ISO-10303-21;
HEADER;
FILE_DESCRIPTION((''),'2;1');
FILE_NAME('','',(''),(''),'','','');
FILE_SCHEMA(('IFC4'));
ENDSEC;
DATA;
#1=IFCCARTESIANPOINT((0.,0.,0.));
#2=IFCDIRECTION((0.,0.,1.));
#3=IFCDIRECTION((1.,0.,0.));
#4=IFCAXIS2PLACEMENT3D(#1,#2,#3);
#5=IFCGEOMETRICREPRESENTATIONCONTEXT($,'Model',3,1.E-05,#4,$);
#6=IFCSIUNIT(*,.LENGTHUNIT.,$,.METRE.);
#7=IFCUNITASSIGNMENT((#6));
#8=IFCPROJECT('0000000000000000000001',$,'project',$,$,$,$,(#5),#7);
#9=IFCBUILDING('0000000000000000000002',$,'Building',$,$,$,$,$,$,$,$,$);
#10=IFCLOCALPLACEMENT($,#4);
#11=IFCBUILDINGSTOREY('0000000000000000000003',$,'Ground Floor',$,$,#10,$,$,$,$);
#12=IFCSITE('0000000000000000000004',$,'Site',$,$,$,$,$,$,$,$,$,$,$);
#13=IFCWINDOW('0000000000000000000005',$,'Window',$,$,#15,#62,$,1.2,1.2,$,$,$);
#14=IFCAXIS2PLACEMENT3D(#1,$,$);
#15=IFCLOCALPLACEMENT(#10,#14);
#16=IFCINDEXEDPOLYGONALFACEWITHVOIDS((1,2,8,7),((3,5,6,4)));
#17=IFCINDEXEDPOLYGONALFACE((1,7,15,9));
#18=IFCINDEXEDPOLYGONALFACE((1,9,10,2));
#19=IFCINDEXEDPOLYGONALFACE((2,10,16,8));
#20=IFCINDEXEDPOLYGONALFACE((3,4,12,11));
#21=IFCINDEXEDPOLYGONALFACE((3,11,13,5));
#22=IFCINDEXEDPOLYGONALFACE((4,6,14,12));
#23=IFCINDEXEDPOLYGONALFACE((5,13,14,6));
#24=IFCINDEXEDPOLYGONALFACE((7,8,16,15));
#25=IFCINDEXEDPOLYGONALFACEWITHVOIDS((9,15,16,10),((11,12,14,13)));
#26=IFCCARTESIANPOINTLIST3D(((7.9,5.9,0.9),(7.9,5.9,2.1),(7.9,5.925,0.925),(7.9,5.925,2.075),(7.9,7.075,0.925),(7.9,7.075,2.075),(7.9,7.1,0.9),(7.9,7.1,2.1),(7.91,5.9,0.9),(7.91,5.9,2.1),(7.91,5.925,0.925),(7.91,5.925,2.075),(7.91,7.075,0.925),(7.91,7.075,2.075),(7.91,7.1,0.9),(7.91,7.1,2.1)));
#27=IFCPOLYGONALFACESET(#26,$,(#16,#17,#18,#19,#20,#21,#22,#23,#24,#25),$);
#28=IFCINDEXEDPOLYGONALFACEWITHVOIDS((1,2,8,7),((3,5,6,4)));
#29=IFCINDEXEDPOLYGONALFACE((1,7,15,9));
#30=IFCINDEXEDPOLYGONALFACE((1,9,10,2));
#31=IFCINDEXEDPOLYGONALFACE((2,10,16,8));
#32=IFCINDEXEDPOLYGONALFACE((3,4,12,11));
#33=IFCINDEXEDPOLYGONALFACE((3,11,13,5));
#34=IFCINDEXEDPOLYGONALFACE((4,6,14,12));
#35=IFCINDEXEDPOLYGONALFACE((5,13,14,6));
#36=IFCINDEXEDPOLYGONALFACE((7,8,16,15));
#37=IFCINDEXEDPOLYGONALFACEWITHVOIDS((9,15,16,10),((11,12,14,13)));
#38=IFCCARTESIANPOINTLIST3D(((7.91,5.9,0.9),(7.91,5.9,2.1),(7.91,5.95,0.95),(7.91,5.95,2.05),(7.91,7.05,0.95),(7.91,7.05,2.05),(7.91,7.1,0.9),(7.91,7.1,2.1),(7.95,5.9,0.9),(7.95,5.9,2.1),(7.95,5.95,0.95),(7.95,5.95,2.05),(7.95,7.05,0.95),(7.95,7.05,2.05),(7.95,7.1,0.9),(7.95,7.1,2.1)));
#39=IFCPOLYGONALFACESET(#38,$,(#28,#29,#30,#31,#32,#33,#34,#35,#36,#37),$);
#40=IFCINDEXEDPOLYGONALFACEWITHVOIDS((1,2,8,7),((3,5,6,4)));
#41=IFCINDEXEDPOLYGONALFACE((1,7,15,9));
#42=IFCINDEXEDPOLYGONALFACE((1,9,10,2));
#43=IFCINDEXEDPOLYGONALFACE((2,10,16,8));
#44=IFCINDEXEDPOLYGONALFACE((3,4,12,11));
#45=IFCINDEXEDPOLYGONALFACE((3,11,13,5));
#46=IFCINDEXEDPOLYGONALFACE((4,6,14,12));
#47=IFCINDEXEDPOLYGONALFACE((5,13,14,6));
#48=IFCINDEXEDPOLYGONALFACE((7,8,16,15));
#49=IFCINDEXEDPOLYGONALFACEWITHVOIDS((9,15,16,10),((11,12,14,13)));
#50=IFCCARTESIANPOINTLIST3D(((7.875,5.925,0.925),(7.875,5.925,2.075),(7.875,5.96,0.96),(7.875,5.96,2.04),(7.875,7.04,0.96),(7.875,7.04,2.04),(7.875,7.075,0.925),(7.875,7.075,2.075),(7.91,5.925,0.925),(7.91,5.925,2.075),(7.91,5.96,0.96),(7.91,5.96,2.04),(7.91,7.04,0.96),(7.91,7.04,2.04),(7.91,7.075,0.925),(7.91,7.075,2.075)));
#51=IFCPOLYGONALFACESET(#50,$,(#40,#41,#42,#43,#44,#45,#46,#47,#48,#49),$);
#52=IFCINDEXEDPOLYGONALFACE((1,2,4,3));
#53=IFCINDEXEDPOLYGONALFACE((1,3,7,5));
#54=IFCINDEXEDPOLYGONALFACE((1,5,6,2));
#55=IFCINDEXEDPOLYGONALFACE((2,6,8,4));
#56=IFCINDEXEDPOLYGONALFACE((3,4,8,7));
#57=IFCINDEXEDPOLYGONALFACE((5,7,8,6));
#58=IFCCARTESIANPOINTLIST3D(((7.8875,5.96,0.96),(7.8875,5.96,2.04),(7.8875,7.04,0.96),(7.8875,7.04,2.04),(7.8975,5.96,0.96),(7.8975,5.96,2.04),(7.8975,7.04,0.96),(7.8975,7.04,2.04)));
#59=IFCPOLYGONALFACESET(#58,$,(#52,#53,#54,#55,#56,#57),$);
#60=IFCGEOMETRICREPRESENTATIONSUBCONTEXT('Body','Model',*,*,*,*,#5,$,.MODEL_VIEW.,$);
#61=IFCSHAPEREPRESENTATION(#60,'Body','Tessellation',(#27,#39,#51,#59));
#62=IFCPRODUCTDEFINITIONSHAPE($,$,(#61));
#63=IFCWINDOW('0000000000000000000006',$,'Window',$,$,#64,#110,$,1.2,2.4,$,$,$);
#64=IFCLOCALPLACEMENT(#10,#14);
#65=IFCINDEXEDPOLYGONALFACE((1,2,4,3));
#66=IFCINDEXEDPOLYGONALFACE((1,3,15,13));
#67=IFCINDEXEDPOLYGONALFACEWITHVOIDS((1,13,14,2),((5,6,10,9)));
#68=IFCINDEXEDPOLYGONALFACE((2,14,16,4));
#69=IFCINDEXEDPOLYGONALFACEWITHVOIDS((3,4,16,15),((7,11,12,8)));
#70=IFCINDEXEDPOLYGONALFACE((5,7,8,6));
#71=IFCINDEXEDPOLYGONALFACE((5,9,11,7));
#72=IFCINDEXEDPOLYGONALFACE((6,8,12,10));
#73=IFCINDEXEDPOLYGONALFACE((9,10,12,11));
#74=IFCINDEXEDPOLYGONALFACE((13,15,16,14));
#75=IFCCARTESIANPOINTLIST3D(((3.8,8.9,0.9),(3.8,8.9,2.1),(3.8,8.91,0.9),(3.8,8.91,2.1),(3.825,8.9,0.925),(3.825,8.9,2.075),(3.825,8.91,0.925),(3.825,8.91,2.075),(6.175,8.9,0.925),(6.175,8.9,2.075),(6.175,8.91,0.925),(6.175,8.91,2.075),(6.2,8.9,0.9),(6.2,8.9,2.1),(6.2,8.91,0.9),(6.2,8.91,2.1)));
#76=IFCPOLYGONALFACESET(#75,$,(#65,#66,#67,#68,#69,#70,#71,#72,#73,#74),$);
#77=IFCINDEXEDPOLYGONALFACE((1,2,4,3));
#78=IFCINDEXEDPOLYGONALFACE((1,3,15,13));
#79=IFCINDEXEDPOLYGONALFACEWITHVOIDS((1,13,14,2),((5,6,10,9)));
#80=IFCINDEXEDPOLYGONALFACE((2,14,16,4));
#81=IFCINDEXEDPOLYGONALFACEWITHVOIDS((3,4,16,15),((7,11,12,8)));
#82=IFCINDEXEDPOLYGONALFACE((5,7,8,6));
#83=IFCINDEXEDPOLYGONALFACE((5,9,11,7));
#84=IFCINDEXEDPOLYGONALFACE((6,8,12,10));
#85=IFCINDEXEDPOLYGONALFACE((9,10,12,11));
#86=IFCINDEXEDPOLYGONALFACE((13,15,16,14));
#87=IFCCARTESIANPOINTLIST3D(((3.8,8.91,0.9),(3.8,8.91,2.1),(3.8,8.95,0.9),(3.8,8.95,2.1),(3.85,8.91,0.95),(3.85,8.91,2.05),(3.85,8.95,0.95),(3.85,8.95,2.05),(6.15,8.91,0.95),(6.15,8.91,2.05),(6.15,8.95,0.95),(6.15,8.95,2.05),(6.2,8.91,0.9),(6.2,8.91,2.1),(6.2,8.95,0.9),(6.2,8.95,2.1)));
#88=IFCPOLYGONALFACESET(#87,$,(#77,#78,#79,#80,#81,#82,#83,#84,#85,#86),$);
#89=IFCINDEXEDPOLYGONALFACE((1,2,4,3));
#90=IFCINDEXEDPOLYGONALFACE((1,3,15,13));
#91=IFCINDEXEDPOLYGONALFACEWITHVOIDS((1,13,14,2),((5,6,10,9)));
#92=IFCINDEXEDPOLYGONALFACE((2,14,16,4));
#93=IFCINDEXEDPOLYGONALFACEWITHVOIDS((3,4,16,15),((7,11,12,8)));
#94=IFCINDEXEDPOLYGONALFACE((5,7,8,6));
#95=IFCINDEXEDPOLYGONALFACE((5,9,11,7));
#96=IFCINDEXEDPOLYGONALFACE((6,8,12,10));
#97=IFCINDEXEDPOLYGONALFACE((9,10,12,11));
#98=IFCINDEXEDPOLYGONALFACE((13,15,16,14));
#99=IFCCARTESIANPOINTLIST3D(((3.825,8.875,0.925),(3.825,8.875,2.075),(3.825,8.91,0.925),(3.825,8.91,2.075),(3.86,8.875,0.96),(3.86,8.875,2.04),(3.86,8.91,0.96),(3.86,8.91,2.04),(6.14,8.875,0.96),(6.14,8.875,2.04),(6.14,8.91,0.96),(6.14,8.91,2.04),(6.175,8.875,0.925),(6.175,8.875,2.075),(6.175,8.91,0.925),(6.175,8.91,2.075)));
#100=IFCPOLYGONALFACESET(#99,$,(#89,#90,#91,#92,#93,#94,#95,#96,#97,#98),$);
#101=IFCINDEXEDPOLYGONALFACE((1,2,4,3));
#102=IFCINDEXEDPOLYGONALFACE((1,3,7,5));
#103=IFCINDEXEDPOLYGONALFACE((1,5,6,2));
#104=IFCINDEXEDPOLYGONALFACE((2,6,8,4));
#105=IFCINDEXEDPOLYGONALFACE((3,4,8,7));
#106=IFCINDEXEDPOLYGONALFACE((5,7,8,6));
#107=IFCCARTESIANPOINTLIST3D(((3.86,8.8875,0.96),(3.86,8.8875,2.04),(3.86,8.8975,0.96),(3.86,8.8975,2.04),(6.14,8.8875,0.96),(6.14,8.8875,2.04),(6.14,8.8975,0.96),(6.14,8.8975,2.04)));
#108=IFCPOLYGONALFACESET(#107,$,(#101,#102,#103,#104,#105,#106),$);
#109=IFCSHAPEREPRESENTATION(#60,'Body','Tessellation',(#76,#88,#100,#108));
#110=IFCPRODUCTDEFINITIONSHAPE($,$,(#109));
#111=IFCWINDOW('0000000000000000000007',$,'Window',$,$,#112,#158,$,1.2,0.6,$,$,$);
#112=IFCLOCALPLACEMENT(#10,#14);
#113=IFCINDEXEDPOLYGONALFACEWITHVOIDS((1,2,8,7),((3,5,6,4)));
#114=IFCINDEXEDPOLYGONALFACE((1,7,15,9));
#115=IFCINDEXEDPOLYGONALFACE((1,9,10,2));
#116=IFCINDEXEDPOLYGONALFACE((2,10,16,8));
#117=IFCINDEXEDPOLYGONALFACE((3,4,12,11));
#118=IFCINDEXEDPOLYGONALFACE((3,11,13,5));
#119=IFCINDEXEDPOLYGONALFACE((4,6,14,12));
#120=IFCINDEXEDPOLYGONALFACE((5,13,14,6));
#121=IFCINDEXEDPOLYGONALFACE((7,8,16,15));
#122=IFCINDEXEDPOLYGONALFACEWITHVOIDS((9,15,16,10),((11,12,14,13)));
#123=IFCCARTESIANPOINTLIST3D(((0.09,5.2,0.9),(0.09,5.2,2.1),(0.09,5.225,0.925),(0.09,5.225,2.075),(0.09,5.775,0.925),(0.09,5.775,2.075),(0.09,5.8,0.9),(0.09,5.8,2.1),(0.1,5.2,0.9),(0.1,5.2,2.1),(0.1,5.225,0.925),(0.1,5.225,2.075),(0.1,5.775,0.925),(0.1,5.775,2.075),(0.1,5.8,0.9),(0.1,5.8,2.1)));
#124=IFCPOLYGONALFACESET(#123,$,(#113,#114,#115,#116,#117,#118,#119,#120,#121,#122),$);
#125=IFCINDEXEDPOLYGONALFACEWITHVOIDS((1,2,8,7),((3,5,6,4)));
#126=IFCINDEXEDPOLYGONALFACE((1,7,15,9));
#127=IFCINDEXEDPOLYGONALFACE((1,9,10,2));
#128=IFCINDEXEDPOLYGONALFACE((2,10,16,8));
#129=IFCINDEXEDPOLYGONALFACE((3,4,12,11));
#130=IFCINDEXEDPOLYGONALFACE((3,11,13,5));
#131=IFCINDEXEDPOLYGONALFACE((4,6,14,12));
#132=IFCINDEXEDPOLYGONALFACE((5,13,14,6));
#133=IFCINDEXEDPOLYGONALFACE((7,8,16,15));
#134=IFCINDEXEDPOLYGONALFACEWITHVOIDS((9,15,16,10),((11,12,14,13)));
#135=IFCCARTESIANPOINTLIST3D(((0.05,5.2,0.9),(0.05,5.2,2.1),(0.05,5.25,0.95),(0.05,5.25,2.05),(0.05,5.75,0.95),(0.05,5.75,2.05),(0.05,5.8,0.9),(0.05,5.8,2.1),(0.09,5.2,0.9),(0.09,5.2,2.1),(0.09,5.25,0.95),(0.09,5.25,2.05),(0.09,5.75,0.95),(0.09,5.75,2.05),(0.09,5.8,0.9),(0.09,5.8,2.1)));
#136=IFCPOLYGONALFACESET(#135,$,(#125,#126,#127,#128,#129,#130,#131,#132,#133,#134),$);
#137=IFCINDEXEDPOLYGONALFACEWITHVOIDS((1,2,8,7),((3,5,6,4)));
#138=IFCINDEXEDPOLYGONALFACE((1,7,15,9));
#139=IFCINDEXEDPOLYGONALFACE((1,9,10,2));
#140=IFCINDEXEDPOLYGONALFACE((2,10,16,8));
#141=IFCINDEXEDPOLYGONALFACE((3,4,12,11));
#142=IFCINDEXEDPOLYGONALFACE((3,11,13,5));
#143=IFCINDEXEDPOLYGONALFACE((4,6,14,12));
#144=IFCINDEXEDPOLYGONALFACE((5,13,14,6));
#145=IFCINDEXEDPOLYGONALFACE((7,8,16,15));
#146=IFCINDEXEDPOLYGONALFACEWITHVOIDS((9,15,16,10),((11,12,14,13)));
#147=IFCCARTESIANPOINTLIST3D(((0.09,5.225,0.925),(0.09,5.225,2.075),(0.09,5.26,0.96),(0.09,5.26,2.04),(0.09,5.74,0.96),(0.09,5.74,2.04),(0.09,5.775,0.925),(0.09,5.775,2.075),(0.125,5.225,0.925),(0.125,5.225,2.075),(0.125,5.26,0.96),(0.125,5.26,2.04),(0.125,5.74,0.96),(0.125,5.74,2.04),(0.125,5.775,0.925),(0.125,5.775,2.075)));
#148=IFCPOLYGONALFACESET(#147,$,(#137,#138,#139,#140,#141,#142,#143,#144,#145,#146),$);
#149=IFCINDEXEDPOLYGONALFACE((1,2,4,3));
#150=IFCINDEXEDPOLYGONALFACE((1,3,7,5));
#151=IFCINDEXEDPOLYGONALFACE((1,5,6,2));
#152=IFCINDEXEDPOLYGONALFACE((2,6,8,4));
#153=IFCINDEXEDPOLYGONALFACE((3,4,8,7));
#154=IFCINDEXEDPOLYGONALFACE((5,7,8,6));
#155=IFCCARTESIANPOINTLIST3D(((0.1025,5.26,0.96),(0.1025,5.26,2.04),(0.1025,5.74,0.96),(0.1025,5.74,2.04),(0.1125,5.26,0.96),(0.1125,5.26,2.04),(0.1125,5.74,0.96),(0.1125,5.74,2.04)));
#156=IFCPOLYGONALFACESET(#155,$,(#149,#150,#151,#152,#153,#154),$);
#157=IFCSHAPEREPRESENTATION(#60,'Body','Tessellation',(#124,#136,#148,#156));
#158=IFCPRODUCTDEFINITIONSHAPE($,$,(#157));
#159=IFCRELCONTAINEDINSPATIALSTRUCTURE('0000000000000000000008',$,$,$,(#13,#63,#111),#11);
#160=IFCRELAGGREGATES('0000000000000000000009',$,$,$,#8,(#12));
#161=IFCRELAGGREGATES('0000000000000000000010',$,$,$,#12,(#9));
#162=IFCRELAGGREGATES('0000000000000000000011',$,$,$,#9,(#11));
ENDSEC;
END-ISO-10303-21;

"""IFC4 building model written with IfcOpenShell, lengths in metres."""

from ifc_helpers import new_model, si_unit, frame, origin_with_axes, place, context, subcontext, project, spatial, line, indexed_curve, outline, extrude, element, save


model = new_model("IFC4")

# Units and contexts
model_context = context("Model", 3, precision=1e-05, world=origin_with_axes())
body_context = subcontext(model_context, "Body", "Model", "MODEL_VIEW")
ifc_project = project(units=[si_unit("LENGTHUNIT", "METRE")], contexts=[model_context])

# Site, building, storey
site = spatial("IfcSite", under=ifc_project, Name="Site")
building = spatial("IfcBuilding", under=site, Name="Building")
storey_placement = place(None, origin_with_axes())
storey = spatial("IfcBuildingStorey", under=building, at=storey_placement, Name="Ground Floor")

# Windows
window_1_placement = place(storey_placement, frame((8.0, 5.9, 0.9), z_axis=(0.0, 0.0, 1.0), x_axis=(0.0, 1.0, 0.0)))
element("IfcWindow", 1, at=window_1_placement, inside=storey, Name="Window", OverallHeight=1.2, OverallWidth=1.2, context=body_context, shape_type="SweptSolid", body=[
    extrude(outline(indexed_curve([(0.0, 0.0), (1.2, 0.0), (1.2, 1.2), (0.0, 1.2)], segments=[line(1, 2, 3, 4, 1)]), holes=[indexed_curve([(0.025, 0.025), (1.175, 0.025), (1.175, 1.175), (0.025, 1.175)], segments=[line(1, 2, 3, 4, 1)])]), frame((0.0, 0.09, 0.0), z_axis=(0.0, -1.0, 0.0), x_axis=(1.0, 0.0, 0.0)), (0.0, 0.0, -1.0), 0.01),
    extrude(outline(indexed_curve([(0.0, 0.0), (1.2, 0.0), (1.2, 1.2), (0.0, 1.2)], segments=[line(1, 2, 3, 4, 1)]), holes=[indexed_curve([(0.05, 0.05), (1.15, 0.05), (1.15, 1.15), (0.05, 1.15)], segments=[line(1, 2, 3, 4, 1)])]), frame((0.0, 0.05, 0.0), z_axis=(0.0, -1.0, 0.0), x_axis=(1.0, 0.0, 0.0)), (0.0, 0.0, -1.0), 0.04),
    extrude(outline(indexed_curve([(0.0, 0.0), (1.15, 0.0), (1.15, 1.15), (0.0, 1.15)], segments=[line(1, 2, 3, 4, 1)]), holes=[indexed_curve([(0.035, 0.035), (1.115, 0.035), (1.115, 1.115), (0.035, 1.115)], segments=[line(1, 2, 3, 4, 1)])]), frame((0.025, 0.09, 0.025), z_axis=(0.0, -1.0, 0.0), x_axis=(1.0, 0.0, 0.0)), (0.0, 0.0, -1.0), 0.035),
    extrude(outline(indexed_curve([(0.035, 0.035), (1.115, 0.035), (1.115, 1.115), (0.035, 1.115)], segments=[line(1, 2, 3, 4, 1)])), frame((0.025, 0.1025, 0.025), z_axis=(0.0, -1.0, 0.0), x_axis=(1.0, 0.0, 0.0)), (0.0, 0.0, -1.0), 0.01),
])
window_2_placement = place(storey_placement, frame((6.2, 9.0, 0.9), z_axis=(0.0, 0.0, 1.0), x_axis=(-1.0, 0.0, 0.0)))
element("IfcWindow", 2, at=window_2_placement, inside=storey, Name="Window", OverallHeight=1.2, OverallWidth=2.4, context=body_context, shape_type="SweptSolid", body=[
    extrude(outline(indexed_curve([(0.0, 0.0), (2.4, 0.0), (2.4, 1.2), (0.0, 1.2)], segments=[line(1, 2, 3, 4, 1)]), holes=[indexed_curve([(0.025, 0.025), (2.375, 0.025), (2.375, 1.175), (0.025, 1.175)], segments=[line(1, 2, 3, 4, 1)])]), frame((0.0, 0.09, 0.0), z_axis=(0.0, -1.0, 0.0), x_axis=(1.0, 0.0, 0.0)), (0.0, 0.0, -1.0), 0.01),
    extrude(outline(indexed_curve([(0.0, 0.0), (2.4, 0.0), (2.4, 1.2), (0.0, 1.2)], segments=[line(1, 2, 3, 4, 1)]), holes=[indexed_curve([(0.05, 0.05), (2.35, 0.05), (2.35, 1.15), (0.05, 1.15)], segments=[line(1, 2, 3, 4, 1)])]), frame((0.0, 0.05, 0.0), z_axis=(0.0, -1.0, 0.0), x_axis=(1.0, 0.0, 0.0)), (0.0, 0.0, -1.0), 0.04),
    extrude(outline(indexed_curve([(0.0, 0.0), (2.35, 0.0), (2.35, 1.15), (0.0, 1.15)], segments=[line(1, 2, 3, 4, 1)]), holes=[indexed_curve([(0.035, 0.035), (2.315, 0.035), (2.315, 1.115), (0.035, 1.115)], segments=[line(1, 2, 3, 4, 1)])]), frame((0.025, 0.09, 0.025), z_axis=(0.0, -1.0, 0.0), x_axis=(1.0, 0.0, 0.0)), (0.0, 0.0, -1.0), 0.035),
    extrude(outline(indexed_curve([(0.035, 0.035), (2.315, 0.035), (2.315, 1.115), (0.035, 1.115)], segments=[line(1, 2, 3, 4, 1)])), frame((0.025, 0.1025, 0.025), z_axis=(0.0, -1.0, 0.0), x_axis=(1.0, 0.0, 0.0)), (0.0, 0.0, -1.0), 0.01),
])
window_3_placement = place(storey_placement, frame((0.0, 5.8, 0.9), z_axis=(0.0, 0.0, 1.0), x_axis=(0.0, -1.0, 0.0)))
element("IfcWindow", 3, at=window_3_placement, inside=storey, Name="Window", OverallHeight=1.2, OverallWidth=0.6, context=body_context, shape_type="SweptSolid", body=[
    extrude(outline(indexed_curve([(0.0, 0.0), (0.6, 0.0), (0.6, 1.2), (0.0, 1.2)], segments=[line(1, 2, 3, 4, 1)]), holes=[indexed_curve([(0.025, 0.025), (0.575, 0.025), (0.575, 1.175), (0.025, 1.175)], segments=[line(1, 2, 3, 4, 1)])]), frame((0.0, 0.09, 0.0), z_axis=(0.0, -1.0, 0.0), x_axis=(1.0, 0.0, 0.0)), (0.0, 0.0, -1.0), 0.01),
    extrude(outline(indexed_curve([(0.0, 0.0), (0.6, 0.0), (0.6, 1.2), (0.0, 1.2)], segments=[line(1, 2, 3, 4, 1)]), holes=[indexed_curve([(0.05, 0.05), (0.55, 0.05), (0.55, 1.15), (0.05, 1.15)], segments=[line(1, 2, 3, 4, 1)])]), frame((0.0, 0.05, 0.0), z_axis=(0.0, -1.0, 0.0), x_axis=(1.0, 0.0, 0.0)), (0.0, 0.0, -1.0), 0.04),
    extrude(outline(indexed_curve([(0.0, 0.0), (0.55, 0.0), (0.55, 1.15), (0.0, 1.15)], segments=[line(1, 2, 3, 4, 1)]), holes=[indexed_curve([(0.035, 0.035), (0.515, 0.035), (0.515, 1.115), (0.035, 1.115)], segments=[line(1, 2, 3, 4, 1)])]), frame((0.025, 0.09, 0.025), z_axis=(0.0, -1.0, 0.0), x_axis=(1.0, 0.0, 0.0)), (0.0, 0.0, -1.0), 0.035),
    extrude(outline(indexed_curve([(0.035, 0.035), (0.515, 0.035), (0.515, 1.115), (0.035, 1.115)], segments=[line(1, 2, 3, 4, 1)])), frame((0.025, 0.1025, 0.025), z_axis=(0.0, -1.0, 0.0), x_axis=(1.0, 0.0, 0.0)), (0.0, 0.0, -1.0), 0.01),
])

save(model, "model.ifc")
